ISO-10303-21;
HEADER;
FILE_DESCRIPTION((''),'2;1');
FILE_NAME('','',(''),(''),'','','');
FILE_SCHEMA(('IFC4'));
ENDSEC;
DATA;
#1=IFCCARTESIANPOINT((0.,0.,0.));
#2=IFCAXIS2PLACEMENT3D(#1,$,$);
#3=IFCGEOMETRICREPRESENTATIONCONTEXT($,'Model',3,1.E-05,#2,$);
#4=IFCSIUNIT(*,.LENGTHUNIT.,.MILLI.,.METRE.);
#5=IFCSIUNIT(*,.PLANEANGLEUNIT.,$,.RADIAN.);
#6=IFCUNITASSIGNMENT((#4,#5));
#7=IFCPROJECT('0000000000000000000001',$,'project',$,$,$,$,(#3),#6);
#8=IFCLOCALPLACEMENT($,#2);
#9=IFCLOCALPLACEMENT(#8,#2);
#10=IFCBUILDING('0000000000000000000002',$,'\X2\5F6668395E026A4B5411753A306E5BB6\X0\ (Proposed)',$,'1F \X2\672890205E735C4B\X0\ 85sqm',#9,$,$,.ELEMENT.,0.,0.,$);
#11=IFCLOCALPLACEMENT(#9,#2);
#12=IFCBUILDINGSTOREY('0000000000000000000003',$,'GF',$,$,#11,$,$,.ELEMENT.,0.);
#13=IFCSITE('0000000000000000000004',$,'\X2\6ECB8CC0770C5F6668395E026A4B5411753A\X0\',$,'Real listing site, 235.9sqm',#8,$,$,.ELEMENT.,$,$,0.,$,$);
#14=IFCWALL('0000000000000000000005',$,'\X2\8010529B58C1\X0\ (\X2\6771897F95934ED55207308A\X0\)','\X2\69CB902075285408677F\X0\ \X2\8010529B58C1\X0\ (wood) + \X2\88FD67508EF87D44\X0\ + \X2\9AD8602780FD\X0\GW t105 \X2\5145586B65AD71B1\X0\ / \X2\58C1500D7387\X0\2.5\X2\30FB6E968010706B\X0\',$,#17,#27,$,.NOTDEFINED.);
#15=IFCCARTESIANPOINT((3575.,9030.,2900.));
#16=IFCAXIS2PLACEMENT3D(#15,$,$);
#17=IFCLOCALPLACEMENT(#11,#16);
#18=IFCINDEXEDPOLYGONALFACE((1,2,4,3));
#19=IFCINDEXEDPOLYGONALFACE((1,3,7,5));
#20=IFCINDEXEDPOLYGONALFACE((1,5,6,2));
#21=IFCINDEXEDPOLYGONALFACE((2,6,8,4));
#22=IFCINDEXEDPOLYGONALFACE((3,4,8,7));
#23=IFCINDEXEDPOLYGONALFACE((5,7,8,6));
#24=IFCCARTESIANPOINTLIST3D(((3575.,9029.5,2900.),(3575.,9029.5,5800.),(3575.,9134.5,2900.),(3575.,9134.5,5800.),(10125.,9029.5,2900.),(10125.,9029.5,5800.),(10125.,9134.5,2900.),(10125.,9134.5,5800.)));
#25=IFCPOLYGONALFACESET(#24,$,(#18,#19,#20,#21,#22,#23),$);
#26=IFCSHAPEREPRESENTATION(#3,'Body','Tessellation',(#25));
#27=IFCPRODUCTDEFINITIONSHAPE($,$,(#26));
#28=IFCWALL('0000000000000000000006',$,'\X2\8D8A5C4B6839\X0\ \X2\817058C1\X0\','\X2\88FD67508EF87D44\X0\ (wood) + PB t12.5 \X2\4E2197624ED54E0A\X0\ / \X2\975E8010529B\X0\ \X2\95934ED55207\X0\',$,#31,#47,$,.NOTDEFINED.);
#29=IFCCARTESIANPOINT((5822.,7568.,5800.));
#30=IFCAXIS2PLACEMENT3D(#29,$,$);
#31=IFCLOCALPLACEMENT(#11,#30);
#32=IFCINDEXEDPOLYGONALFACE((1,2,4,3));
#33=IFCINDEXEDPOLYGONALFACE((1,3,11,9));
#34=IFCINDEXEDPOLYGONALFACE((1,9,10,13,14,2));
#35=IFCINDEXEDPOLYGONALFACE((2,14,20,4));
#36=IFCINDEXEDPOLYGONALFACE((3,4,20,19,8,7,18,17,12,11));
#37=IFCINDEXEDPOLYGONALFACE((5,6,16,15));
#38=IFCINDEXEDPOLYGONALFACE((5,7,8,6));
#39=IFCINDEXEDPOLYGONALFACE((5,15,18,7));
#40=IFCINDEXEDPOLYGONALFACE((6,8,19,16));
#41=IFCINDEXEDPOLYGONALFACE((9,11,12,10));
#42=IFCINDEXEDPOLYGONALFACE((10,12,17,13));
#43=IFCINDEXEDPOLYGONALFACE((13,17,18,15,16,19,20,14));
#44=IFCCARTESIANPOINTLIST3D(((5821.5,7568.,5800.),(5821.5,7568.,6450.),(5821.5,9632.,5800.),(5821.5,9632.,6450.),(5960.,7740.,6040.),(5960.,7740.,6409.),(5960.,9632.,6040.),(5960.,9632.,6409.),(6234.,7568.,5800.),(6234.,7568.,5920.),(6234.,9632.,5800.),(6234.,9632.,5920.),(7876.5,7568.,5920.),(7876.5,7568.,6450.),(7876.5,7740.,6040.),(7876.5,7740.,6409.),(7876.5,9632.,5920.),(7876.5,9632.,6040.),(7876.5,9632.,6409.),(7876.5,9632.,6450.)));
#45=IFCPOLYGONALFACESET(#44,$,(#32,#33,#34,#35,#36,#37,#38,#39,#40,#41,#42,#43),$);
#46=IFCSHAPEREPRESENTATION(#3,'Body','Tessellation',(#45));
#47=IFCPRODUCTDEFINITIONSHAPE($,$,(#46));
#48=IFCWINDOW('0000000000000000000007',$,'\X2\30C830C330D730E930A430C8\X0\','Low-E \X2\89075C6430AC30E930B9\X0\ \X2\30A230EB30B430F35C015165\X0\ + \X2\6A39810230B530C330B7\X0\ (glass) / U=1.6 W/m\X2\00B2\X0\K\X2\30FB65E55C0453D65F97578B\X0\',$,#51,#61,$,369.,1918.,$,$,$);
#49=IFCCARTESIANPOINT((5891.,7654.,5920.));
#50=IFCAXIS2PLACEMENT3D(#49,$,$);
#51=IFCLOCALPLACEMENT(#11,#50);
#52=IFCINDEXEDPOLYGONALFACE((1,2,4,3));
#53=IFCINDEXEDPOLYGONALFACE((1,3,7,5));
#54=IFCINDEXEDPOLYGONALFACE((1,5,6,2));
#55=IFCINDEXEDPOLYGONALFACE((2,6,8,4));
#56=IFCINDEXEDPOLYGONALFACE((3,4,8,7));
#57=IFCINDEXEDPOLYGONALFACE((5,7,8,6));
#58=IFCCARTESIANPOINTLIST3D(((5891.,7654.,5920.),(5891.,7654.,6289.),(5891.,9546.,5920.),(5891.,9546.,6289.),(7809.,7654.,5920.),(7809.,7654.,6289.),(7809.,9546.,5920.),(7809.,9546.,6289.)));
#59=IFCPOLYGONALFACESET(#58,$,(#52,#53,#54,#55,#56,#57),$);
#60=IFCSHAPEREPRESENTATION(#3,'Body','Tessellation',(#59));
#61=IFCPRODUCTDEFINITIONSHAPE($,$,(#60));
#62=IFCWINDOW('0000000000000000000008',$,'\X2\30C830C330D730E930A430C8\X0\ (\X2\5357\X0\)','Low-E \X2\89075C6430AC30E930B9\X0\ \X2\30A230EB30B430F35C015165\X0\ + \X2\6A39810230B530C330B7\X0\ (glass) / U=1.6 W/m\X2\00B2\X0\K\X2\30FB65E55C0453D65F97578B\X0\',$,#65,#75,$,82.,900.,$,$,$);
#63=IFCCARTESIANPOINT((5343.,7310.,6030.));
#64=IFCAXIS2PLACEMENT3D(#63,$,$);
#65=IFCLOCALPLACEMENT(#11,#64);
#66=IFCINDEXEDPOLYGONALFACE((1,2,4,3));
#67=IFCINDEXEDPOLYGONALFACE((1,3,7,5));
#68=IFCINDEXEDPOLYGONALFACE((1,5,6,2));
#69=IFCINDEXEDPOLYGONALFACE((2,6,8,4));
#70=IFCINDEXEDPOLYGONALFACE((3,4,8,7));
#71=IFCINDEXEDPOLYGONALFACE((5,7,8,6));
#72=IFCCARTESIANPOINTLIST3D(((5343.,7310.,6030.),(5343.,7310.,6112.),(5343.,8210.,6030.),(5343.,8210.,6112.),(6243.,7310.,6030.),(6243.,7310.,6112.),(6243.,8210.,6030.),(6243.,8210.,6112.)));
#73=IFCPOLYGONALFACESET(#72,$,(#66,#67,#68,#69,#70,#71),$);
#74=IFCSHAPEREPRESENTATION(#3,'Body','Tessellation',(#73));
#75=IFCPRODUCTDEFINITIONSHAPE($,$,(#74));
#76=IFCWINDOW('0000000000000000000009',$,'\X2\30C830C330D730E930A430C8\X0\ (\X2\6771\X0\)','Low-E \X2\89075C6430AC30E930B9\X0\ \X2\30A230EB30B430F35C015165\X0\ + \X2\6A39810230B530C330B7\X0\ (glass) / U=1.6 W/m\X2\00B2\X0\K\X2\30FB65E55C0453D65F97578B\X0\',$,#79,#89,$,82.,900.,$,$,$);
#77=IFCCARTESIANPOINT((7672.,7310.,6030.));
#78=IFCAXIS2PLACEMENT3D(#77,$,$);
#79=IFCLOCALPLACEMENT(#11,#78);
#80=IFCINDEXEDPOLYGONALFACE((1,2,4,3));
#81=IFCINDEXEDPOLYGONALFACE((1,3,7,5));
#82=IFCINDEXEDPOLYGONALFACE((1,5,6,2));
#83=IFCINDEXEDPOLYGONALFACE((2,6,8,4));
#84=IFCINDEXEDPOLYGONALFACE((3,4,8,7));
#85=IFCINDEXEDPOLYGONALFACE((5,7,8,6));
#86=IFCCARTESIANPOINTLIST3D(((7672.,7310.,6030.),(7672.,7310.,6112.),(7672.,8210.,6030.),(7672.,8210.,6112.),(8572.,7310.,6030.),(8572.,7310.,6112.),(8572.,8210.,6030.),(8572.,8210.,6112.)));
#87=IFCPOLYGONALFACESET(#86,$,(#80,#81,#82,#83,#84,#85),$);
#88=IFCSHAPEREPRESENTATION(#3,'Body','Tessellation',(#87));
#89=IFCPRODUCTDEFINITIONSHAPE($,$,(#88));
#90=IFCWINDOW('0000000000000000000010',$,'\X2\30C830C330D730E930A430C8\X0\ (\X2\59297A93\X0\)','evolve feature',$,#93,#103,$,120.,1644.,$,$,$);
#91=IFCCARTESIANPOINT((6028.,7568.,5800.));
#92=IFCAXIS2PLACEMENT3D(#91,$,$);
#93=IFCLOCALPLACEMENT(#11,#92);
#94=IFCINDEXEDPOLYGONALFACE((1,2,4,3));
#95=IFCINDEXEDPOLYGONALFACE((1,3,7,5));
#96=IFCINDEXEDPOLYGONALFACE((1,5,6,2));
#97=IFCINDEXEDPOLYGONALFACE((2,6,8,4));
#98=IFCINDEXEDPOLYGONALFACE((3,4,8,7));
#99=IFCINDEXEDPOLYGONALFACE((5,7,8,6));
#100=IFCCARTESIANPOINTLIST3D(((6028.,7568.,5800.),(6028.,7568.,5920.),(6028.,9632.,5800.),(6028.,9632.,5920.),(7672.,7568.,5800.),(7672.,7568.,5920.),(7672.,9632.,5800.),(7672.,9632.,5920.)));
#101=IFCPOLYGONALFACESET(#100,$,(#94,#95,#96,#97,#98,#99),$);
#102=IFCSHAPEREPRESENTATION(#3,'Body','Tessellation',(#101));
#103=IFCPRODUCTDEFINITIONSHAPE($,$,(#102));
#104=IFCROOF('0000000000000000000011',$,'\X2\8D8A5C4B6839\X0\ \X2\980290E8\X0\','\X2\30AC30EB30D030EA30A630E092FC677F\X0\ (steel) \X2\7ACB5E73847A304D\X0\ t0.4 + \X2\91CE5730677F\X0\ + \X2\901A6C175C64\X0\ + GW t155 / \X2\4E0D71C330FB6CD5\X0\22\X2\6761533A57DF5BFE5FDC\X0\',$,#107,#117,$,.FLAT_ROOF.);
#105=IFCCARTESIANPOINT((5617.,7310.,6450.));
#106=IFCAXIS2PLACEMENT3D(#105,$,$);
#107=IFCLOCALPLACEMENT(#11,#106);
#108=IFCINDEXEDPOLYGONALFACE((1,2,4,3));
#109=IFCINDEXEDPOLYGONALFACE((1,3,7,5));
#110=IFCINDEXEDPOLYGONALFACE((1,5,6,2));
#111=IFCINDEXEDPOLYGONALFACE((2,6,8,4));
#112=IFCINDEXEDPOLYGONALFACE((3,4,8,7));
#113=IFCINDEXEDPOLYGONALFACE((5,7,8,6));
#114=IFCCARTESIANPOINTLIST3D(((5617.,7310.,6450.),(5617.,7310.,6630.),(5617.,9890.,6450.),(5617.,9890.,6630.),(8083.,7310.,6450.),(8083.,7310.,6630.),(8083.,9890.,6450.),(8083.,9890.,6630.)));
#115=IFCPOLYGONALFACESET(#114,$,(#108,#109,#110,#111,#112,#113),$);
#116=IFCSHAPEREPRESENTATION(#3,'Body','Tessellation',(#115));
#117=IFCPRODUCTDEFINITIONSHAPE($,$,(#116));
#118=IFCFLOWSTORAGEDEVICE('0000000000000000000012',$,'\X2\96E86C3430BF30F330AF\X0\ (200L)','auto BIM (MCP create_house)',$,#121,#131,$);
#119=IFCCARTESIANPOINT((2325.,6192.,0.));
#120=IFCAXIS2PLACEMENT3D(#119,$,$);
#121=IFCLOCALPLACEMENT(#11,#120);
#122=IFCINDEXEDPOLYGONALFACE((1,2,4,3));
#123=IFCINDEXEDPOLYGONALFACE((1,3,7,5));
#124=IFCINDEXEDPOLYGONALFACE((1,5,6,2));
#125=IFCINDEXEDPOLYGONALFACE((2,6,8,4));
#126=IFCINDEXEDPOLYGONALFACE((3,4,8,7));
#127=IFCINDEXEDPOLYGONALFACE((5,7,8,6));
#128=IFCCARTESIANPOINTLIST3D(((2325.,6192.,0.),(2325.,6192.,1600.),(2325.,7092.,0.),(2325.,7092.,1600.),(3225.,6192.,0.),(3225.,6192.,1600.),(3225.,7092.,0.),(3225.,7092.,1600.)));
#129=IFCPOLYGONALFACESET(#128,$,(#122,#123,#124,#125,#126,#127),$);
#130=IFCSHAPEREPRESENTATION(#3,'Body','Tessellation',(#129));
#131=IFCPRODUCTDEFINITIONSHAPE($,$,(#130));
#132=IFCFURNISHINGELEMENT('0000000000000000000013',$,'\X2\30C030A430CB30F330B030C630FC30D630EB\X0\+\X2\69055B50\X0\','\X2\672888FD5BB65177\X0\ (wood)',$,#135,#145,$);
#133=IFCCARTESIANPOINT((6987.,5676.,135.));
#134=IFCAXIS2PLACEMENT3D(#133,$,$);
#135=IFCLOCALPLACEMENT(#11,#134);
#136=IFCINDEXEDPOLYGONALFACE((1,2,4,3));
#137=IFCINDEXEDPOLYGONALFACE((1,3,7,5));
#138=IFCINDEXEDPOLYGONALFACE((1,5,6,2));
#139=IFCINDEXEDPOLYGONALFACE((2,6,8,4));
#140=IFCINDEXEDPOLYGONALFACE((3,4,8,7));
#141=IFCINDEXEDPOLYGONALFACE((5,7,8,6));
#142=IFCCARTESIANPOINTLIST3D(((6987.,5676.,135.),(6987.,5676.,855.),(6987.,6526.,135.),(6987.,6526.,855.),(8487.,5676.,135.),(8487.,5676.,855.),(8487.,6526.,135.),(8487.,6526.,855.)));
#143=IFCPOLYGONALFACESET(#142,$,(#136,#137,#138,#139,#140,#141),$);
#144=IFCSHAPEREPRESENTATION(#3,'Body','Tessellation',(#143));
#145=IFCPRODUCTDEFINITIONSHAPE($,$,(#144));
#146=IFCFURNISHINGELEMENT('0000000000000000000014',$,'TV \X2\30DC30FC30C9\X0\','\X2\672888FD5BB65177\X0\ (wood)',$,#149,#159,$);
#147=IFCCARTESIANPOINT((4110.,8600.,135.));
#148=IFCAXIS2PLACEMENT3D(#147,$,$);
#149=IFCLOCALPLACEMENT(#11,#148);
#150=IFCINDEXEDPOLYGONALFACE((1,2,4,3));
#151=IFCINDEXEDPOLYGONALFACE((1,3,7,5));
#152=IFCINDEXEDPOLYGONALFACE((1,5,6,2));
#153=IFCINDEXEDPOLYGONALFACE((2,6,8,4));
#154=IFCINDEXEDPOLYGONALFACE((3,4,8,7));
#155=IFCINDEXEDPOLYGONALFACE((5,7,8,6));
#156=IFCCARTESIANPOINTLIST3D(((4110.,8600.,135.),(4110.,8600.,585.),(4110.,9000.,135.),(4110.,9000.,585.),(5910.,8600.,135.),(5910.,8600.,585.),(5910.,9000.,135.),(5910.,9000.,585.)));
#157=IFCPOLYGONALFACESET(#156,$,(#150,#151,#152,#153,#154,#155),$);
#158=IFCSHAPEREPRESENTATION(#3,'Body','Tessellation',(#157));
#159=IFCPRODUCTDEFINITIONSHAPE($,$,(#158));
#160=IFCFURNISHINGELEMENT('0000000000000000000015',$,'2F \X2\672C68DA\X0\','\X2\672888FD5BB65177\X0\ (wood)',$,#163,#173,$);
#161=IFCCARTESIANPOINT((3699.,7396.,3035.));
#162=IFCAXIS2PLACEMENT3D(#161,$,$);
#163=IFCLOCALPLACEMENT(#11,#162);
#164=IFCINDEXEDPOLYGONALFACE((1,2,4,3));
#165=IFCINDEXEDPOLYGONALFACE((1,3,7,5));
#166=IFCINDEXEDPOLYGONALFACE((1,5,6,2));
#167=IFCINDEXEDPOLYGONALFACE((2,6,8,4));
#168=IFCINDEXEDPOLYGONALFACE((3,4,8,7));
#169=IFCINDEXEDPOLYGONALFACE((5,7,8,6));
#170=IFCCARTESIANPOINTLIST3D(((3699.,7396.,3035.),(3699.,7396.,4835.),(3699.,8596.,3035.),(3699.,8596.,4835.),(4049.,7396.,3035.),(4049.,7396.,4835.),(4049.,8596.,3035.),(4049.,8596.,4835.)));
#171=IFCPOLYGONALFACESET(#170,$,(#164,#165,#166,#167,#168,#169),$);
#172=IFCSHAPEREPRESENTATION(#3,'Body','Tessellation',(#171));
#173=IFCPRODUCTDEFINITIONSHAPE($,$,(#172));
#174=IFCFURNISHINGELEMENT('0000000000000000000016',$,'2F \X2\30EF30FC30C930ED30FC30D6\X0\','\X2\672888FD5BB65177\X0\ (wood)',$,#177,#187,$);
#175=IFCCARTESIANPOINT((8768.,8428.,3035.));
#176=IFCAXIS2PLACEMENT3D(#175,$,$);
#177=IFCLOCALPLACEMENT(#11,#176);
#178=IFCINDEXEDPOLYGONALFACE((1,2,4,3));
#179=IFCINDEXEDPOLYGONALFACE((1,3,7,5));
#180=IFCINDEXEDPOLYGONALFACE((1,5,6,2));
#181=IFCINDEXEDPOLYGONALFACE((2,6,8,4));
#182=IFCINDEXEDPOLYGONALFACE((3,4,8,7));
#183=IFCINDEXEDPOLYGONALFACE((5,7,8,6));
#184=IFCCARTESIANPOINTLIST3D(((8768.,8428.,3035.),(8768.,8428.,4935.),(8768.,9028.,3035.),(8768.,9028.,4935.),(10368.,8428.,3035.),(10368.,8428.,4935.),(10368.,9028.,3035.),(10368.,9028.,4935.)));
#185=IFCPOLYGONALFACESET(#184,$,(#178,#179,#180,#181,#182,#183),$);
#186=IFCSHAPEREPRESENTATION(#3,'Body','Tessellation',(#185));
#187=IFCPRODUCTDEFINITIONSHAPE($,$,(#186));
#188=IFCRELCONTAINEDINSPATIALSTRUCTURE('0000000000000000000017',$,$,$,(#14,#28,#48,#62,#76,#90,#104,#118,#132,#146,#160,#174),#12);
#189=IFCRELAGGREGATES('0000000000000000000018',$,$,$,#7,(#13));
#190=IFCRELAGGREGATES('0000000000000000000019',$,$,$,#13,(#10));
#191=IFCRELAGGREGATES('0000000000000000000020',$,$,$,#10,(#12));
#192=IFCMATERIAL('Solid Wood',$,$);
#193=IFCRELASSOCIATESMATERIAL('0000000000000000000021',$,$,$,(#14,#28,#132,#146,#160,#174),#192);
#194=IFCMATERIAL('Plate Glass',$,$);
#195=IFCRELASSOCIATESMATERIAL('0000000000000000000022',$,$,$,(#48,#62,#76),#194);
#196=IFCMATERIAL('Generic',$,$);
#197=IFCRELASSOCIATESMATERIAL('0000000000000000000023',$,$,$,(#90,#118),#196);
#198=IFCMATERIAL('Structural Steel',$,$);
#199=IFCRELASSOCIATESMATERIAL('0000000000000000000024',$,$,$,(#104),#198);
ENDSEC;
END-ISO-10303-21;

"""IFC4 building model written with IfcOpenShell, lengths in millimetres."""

from ifc_helpers import new_model, si_unit, frame, frame_2d, origin, place, context, project, spatial, rectangle, extrude, material, element, fill, save


model = new_model("IFC4")

# Units and contexts
model_context = context("Model", 3, precision=1e-05, world=origin())
ifc_project = project(units=[si_unit("LENGTHUNIT", "METRE", prefix="MILLI"), si_unit("PLANEANGLEUNIT", "RADIAN")], contexts=[model_context])

# Site, building, storey
site_placement = place(None, origin())
site = spatial("IfcSite", under=ifc_project, at=site_placement, Name="滋賀県彦根市橋向町", ObjectType="Real listing site, 235.9sqm", CompositionType="ELEMENT", RefElevation=0.0)
building_placement = place(site_placement, origin())
building = spatial("IfcBuilding", under=site, at=building_placement, Name="彦根市橋向町の家 (Proposed)", ObjectType="1F 木造平屋 85sqm", CompositionType="ELEMENT", ElevationOfRefHeight=0.0, ElevationOfTerrain=0.0)
storey_placement = place(building_placement, origin())
storey = spatial("IfcBuildingStorey", under=building, at=storey_placement, Name="GF", CompositionType="ELEMENT", Elevation=0.0)

# Wall
ifc_material_1 = material(Name="Solid Wood")
wall_1_placement = place(storey_placement, frame((3575.0, 9030.0, 2900.0)))
element("IfcWall", 1, at=wall_1_placement, inside=storey, material=ifc_material_1, Name="耐力壁 (東西間仕切り)", Description="構造用合板 耐力壁 (wood) + 製材軸組 + 高性能GW t105 充填断熱 / 壁倍率2.5・準耐火", PredefinedType="NOTDEFINED", context=model_context, shape_type="SweptSolid", body=[
    extrude(rectangle(XDim=6550.0, YDim=105.0, at=frame_2d((3275.0, 52.0))), frame((3575.0, 9030.0, 2900.0)), (0.0, 0.0, 1.0), 2900.0),
])

# Wall, openings, windows
wall_2_placement = place(storey_placement, frame((5822.0, 7568.0, 5800.0)))
wall_2 = element("IfcWall", 2, at=wall_2_placement, inside=storey, material=ifc_material_1, Name="越屋根 腰壁", Description="製材軸組 (wood) + PB t12.5 両面仕上 / 非耐力 間仕切", PredefinedType="NOTDEFINED", context=model_context, shape_type="SweptSolid", body=[
    extrude(rectangle(XDim=2055.0, YDim=2064.0, at=frame_2d((1027.0, 1032.0))), frame((5822.0, 7568.0, 5800.0)), (0.0, 0.0, 1.0), 650.0),
])
opening_1_placement = place(storey_placement, frame((5891.0, 7654.0, 5920.0)))
opening_1 = element("IfcOpeningElement", 3, at=opening_1_placement, cuts=wall_2, PredefinedType="NOTDEFINED", context=model_context, shape_type="SweptSolid", body=[
    extrude(rectangle(XDim=1918.0, YDim=1892.0, at=frame_2d((959.0, 946.0))), frame((5891.0, 7654.0, 5920.0)), (0.0, 0.0, 1.0), 369.0),
])
opening_2_placement = place(storey_placement, frame((5343.0, 7310.0, 6030.0)))
opening_2 = element("IfcOpeningElement", 4, at=opening_2_placement, cuts=wall_2, PredefinedType="NOTDEFINED", context=model_context, shape_type="SweptSolid", body=[
    extrude(rectangle(XDim=900.0, YDim=900.0, at=frame_2d((450.0, 450.0))), frame((5343.0, 7310.0, 6030.0)), (0.0, 0.0, 1.0), 82.0),
])
opening_3_placement = place(storey_placement, frame((7672.0, 7310.0, 6030.0)))
opening_3 = element("IfcOpeningElement", 5, at=opening_3_placement, cuts=wall_2, PredefinedType="NOTDEFINED", context=model_context, shape_type="SweptSolid", body=[
    extrude(rectangle(XDim=900.0, YDim=900.0, at=frame_2d((450.0, 450.0))), frame((7672.0, 7310.0, 6030.0)), (0.0, 0.0, 1.0), 82.0),
])
opening_4_placement = place(storey_placement, frame((6028.0, 7568.0, 5800.0)))
opening_4 = element("IfcOpeningElement", 6, at=opening_4_placement, cuts=wall_2, PredefinedType="NOTDEFINED", context=model_context, shape_type="SweptSolid", body=[
    extrude(rectangle(XDim=1644.0, YDim=2064.0, at=frame_2d((822.0, 1032.0))), frame((6028.0, 7568.0, 5800.0)), (0.0, 0.0, 1.0), 120.0),
])
ifc_material_2 = material(Name="Plate Glass")
window_1_placement = place(storey_placement, frame((5891.0, 7654.0, 5920.0)))
window_1 = element("IfcWindow", 7, at=window_1_placement, inside=storey, material=ifc_material_2, Name="トップライト", Description="Low-E 複層ガラス アルゴン封入 + 樹脂サッシ (glass) / U=1.6 W/m²K・日射取得型", OverallHeight=369.0, OverallWidth=1918.0, context=model_context, shape_type="SweptSolid", body=[
    extrude(rectangle(XDim=1918.0, YDim=1892.0, at=frame_2d((959.0, 946.0))), frame((5891.0, 7654.0, 5920.0)), (0.0, 0.0, 1.0), 369.0),
])
fill(opening_1, window_1)
window_2_placement = place(storey_placement, frame((5343.0, 7310.0, 6030.0)))
window_2 = element("IfcWindow", 8, at=window_2_placement, inside=storey, material=ifc_material_2, Name="トップライト (南)", Description="Low-E 複層ガラス アルゴン封入 + 樹脂サッシ (glass) / U=1.6 W/m²K・日射取得型", OverallHeight=82.0, OverallWidth=900.0, context=model_context, shape_type="SweptSolid", body=[
    extrude(rectangle(XDim=900.0, YDim=900.0, at=frame_2d((450.0, 450.0))), frame((5343.0, 7310.0, 6030.0)), (0.0, 0.0, 1.0), 82.0),
])
fill(opening_2, window_2)
window_3_placement = place(storey_placement, frame((7672.0, 7310.0, 6030.0)))
window_3 = element("IfcWindow", 9, at=window_3_placement, inside=storey, material=ifc_material_2, Name="トップライト (東)", Description="Low-E 複層ガラス アルゴン封入 + 樹脂サッシ (glass) / U=1.6 W/m²K・日射取得型", OverallHeight=82.0, OverallWidth=900.0, context=model_context, shape_type="SweptSolid", body=[
    extrude(rectangle(XDim=900.0, YDim=900.0, at=frame_2d((450.0, 450.0))), frame((7672.0, 7310.0, 6030.0)), (0.0, 0.0, 1.0), 82.0),
])
fill(opening_3, window_3)
ifc_material_3 = material(Name="Generic")
window_4_placement = place(storey_placement, frame((6028.0, 7568.0, 5800.0)))
window_4 = element("IfcWindow", 10, at=window_4_placement, inside=storey, material=ifc_material_3, Name="トップライト (天窓)", Description="evolve feature", OverallHeight=120.0, OverallWidth=1644.0, context=model_context, shape_type="SweptSolid", body=[
    extrude(rectangle(XDim=1644.0, YDim=2064.0, at=frame_2d((822.0, 1032.0))), frame((6028.0, 7568.0, 5800.0)), (0.0, 0.0, 1.0), 120.0),
])
fill(opening_4, window_4)

# Roof
ifc_material_4 = material(Name="Structural Steel")
roof_placement = place(storey_placement, frame((5617.0, 7310.0, 6450.0)))
element("IfcRoof", 11, at=roof_placement, inside=storey, material=ifc_material_4, Name="越屋根 頂部", Description="ガルバリウム鋼板 (steel) 立平葺き t0.4 + 野地板 + 通気層 + GW t155 / 不燃・法22条区域対応", PredefinedType="FLAT_ROOF", context=model_context, shape_type="SweptSolid", body=[
    extrude(rectangle(XDim=2466.0, YDim=2580.0, at=frame_2d((1233.0, 1290.0))), frame((5617.0, 7310.0, 6450.0)), (0.0, 0.0, 1.0), 180.0),
])

# Flow storage device
flow_storage_device_placement = place(storey_placement, frame((2325.0, 6192.0, 0.0)))
element("IfcFlowStorageDevice", 12, at=flow_storage_device_placement, inside=storey, material=ifc_material_3, Name="雨水タンク (200L)", Description="auto BIM (MCP create_house)", context=model_context, shape_type="SweptSolid", body=[
    extrude(rectangle(XDim=900.0, YDim=900.0, at=frame_2d((450.0, 450.0))), frame((2325.0, 6192.0, 0.0)), (0.0, 0.0, 1.0), 1600.0),
])

# Furnishing elements
furnishing_1_placement = place(storey_placement, frame((6987.0, 5676.0, 135.0)))
element("IfcFurnishingElement", 13, at=furnishing_1_placement, inside=storey, material=ifc_material_1, Name="ダイニングテーブル+椅子", Description="木製家具 (wood)", context=model_context, shape_type="SweptSolid", body=[
    extrude(rectangle(XDim=1500.0, YDim=850.0, at=frame_2d((750.0, 425.0))), frame((6987.0, 5676.0, 135.0)), (0.0, 0.0, 1.0), 720.0),
])
furnishing_2_placement = place(storey_placement, frame((4110.0, 8600.0, 135.0)))
element("IfcFurnishingElement", 14, at=furnishing_2_placement, inside=storey, material=ifc_material_1, Name="TV ボード", Description="木製家具 (wood)", context=model_context, shape_type="SweptSolid", body=[
    extrude(rectangle(XDim=1800.0, YDim=400.0, at=frame_2d((900.0, 200.0))), frame((4110.0, 8600.0, 135.0)), (0.0, 0.0, 1.0), 450.0),
])
furnishing_3_placement = place(storey_placement, frame((3699.0, 7396.0, 3035.0)))
element("IfcFurnishingElement", 15, at=furnishing_3_placement, inside=storey, material=ifc_material_1, Name="2F 本棚", Description="木製家具 (wood)", context=model_context, shape_type="SweptSolid", body=[
    extrude(rectangle(XDim=350.0, YDim=1200.0, at=frame_2d((175.0, 600.0))), frame((3699.0, 7396.0, 3035.0)), (0.0, 0.0, 1.0), 1800.0),
])
furnishing_4_placement = place(storey_placement, frame((8768.0, 8428.0, 3035.0)))
element("IfcFurnishingElement", 16, at=furnishing_4_placement, inside=storey, material=ifc_material_1, Name="2F ワードローブ", Description="木製家具 (wood)", context=model_context, shape_type="SweptSolid", body=[
    extrude(rectangle(XDim=1600.0, YDim=600.0, at=frame_2d((800.0, 300.0))), frame((8768.0, 8428.0, 3035.0)), (0.0, 0.0, 1.0), 1900.0),
])

save(model, "model.ifc")
